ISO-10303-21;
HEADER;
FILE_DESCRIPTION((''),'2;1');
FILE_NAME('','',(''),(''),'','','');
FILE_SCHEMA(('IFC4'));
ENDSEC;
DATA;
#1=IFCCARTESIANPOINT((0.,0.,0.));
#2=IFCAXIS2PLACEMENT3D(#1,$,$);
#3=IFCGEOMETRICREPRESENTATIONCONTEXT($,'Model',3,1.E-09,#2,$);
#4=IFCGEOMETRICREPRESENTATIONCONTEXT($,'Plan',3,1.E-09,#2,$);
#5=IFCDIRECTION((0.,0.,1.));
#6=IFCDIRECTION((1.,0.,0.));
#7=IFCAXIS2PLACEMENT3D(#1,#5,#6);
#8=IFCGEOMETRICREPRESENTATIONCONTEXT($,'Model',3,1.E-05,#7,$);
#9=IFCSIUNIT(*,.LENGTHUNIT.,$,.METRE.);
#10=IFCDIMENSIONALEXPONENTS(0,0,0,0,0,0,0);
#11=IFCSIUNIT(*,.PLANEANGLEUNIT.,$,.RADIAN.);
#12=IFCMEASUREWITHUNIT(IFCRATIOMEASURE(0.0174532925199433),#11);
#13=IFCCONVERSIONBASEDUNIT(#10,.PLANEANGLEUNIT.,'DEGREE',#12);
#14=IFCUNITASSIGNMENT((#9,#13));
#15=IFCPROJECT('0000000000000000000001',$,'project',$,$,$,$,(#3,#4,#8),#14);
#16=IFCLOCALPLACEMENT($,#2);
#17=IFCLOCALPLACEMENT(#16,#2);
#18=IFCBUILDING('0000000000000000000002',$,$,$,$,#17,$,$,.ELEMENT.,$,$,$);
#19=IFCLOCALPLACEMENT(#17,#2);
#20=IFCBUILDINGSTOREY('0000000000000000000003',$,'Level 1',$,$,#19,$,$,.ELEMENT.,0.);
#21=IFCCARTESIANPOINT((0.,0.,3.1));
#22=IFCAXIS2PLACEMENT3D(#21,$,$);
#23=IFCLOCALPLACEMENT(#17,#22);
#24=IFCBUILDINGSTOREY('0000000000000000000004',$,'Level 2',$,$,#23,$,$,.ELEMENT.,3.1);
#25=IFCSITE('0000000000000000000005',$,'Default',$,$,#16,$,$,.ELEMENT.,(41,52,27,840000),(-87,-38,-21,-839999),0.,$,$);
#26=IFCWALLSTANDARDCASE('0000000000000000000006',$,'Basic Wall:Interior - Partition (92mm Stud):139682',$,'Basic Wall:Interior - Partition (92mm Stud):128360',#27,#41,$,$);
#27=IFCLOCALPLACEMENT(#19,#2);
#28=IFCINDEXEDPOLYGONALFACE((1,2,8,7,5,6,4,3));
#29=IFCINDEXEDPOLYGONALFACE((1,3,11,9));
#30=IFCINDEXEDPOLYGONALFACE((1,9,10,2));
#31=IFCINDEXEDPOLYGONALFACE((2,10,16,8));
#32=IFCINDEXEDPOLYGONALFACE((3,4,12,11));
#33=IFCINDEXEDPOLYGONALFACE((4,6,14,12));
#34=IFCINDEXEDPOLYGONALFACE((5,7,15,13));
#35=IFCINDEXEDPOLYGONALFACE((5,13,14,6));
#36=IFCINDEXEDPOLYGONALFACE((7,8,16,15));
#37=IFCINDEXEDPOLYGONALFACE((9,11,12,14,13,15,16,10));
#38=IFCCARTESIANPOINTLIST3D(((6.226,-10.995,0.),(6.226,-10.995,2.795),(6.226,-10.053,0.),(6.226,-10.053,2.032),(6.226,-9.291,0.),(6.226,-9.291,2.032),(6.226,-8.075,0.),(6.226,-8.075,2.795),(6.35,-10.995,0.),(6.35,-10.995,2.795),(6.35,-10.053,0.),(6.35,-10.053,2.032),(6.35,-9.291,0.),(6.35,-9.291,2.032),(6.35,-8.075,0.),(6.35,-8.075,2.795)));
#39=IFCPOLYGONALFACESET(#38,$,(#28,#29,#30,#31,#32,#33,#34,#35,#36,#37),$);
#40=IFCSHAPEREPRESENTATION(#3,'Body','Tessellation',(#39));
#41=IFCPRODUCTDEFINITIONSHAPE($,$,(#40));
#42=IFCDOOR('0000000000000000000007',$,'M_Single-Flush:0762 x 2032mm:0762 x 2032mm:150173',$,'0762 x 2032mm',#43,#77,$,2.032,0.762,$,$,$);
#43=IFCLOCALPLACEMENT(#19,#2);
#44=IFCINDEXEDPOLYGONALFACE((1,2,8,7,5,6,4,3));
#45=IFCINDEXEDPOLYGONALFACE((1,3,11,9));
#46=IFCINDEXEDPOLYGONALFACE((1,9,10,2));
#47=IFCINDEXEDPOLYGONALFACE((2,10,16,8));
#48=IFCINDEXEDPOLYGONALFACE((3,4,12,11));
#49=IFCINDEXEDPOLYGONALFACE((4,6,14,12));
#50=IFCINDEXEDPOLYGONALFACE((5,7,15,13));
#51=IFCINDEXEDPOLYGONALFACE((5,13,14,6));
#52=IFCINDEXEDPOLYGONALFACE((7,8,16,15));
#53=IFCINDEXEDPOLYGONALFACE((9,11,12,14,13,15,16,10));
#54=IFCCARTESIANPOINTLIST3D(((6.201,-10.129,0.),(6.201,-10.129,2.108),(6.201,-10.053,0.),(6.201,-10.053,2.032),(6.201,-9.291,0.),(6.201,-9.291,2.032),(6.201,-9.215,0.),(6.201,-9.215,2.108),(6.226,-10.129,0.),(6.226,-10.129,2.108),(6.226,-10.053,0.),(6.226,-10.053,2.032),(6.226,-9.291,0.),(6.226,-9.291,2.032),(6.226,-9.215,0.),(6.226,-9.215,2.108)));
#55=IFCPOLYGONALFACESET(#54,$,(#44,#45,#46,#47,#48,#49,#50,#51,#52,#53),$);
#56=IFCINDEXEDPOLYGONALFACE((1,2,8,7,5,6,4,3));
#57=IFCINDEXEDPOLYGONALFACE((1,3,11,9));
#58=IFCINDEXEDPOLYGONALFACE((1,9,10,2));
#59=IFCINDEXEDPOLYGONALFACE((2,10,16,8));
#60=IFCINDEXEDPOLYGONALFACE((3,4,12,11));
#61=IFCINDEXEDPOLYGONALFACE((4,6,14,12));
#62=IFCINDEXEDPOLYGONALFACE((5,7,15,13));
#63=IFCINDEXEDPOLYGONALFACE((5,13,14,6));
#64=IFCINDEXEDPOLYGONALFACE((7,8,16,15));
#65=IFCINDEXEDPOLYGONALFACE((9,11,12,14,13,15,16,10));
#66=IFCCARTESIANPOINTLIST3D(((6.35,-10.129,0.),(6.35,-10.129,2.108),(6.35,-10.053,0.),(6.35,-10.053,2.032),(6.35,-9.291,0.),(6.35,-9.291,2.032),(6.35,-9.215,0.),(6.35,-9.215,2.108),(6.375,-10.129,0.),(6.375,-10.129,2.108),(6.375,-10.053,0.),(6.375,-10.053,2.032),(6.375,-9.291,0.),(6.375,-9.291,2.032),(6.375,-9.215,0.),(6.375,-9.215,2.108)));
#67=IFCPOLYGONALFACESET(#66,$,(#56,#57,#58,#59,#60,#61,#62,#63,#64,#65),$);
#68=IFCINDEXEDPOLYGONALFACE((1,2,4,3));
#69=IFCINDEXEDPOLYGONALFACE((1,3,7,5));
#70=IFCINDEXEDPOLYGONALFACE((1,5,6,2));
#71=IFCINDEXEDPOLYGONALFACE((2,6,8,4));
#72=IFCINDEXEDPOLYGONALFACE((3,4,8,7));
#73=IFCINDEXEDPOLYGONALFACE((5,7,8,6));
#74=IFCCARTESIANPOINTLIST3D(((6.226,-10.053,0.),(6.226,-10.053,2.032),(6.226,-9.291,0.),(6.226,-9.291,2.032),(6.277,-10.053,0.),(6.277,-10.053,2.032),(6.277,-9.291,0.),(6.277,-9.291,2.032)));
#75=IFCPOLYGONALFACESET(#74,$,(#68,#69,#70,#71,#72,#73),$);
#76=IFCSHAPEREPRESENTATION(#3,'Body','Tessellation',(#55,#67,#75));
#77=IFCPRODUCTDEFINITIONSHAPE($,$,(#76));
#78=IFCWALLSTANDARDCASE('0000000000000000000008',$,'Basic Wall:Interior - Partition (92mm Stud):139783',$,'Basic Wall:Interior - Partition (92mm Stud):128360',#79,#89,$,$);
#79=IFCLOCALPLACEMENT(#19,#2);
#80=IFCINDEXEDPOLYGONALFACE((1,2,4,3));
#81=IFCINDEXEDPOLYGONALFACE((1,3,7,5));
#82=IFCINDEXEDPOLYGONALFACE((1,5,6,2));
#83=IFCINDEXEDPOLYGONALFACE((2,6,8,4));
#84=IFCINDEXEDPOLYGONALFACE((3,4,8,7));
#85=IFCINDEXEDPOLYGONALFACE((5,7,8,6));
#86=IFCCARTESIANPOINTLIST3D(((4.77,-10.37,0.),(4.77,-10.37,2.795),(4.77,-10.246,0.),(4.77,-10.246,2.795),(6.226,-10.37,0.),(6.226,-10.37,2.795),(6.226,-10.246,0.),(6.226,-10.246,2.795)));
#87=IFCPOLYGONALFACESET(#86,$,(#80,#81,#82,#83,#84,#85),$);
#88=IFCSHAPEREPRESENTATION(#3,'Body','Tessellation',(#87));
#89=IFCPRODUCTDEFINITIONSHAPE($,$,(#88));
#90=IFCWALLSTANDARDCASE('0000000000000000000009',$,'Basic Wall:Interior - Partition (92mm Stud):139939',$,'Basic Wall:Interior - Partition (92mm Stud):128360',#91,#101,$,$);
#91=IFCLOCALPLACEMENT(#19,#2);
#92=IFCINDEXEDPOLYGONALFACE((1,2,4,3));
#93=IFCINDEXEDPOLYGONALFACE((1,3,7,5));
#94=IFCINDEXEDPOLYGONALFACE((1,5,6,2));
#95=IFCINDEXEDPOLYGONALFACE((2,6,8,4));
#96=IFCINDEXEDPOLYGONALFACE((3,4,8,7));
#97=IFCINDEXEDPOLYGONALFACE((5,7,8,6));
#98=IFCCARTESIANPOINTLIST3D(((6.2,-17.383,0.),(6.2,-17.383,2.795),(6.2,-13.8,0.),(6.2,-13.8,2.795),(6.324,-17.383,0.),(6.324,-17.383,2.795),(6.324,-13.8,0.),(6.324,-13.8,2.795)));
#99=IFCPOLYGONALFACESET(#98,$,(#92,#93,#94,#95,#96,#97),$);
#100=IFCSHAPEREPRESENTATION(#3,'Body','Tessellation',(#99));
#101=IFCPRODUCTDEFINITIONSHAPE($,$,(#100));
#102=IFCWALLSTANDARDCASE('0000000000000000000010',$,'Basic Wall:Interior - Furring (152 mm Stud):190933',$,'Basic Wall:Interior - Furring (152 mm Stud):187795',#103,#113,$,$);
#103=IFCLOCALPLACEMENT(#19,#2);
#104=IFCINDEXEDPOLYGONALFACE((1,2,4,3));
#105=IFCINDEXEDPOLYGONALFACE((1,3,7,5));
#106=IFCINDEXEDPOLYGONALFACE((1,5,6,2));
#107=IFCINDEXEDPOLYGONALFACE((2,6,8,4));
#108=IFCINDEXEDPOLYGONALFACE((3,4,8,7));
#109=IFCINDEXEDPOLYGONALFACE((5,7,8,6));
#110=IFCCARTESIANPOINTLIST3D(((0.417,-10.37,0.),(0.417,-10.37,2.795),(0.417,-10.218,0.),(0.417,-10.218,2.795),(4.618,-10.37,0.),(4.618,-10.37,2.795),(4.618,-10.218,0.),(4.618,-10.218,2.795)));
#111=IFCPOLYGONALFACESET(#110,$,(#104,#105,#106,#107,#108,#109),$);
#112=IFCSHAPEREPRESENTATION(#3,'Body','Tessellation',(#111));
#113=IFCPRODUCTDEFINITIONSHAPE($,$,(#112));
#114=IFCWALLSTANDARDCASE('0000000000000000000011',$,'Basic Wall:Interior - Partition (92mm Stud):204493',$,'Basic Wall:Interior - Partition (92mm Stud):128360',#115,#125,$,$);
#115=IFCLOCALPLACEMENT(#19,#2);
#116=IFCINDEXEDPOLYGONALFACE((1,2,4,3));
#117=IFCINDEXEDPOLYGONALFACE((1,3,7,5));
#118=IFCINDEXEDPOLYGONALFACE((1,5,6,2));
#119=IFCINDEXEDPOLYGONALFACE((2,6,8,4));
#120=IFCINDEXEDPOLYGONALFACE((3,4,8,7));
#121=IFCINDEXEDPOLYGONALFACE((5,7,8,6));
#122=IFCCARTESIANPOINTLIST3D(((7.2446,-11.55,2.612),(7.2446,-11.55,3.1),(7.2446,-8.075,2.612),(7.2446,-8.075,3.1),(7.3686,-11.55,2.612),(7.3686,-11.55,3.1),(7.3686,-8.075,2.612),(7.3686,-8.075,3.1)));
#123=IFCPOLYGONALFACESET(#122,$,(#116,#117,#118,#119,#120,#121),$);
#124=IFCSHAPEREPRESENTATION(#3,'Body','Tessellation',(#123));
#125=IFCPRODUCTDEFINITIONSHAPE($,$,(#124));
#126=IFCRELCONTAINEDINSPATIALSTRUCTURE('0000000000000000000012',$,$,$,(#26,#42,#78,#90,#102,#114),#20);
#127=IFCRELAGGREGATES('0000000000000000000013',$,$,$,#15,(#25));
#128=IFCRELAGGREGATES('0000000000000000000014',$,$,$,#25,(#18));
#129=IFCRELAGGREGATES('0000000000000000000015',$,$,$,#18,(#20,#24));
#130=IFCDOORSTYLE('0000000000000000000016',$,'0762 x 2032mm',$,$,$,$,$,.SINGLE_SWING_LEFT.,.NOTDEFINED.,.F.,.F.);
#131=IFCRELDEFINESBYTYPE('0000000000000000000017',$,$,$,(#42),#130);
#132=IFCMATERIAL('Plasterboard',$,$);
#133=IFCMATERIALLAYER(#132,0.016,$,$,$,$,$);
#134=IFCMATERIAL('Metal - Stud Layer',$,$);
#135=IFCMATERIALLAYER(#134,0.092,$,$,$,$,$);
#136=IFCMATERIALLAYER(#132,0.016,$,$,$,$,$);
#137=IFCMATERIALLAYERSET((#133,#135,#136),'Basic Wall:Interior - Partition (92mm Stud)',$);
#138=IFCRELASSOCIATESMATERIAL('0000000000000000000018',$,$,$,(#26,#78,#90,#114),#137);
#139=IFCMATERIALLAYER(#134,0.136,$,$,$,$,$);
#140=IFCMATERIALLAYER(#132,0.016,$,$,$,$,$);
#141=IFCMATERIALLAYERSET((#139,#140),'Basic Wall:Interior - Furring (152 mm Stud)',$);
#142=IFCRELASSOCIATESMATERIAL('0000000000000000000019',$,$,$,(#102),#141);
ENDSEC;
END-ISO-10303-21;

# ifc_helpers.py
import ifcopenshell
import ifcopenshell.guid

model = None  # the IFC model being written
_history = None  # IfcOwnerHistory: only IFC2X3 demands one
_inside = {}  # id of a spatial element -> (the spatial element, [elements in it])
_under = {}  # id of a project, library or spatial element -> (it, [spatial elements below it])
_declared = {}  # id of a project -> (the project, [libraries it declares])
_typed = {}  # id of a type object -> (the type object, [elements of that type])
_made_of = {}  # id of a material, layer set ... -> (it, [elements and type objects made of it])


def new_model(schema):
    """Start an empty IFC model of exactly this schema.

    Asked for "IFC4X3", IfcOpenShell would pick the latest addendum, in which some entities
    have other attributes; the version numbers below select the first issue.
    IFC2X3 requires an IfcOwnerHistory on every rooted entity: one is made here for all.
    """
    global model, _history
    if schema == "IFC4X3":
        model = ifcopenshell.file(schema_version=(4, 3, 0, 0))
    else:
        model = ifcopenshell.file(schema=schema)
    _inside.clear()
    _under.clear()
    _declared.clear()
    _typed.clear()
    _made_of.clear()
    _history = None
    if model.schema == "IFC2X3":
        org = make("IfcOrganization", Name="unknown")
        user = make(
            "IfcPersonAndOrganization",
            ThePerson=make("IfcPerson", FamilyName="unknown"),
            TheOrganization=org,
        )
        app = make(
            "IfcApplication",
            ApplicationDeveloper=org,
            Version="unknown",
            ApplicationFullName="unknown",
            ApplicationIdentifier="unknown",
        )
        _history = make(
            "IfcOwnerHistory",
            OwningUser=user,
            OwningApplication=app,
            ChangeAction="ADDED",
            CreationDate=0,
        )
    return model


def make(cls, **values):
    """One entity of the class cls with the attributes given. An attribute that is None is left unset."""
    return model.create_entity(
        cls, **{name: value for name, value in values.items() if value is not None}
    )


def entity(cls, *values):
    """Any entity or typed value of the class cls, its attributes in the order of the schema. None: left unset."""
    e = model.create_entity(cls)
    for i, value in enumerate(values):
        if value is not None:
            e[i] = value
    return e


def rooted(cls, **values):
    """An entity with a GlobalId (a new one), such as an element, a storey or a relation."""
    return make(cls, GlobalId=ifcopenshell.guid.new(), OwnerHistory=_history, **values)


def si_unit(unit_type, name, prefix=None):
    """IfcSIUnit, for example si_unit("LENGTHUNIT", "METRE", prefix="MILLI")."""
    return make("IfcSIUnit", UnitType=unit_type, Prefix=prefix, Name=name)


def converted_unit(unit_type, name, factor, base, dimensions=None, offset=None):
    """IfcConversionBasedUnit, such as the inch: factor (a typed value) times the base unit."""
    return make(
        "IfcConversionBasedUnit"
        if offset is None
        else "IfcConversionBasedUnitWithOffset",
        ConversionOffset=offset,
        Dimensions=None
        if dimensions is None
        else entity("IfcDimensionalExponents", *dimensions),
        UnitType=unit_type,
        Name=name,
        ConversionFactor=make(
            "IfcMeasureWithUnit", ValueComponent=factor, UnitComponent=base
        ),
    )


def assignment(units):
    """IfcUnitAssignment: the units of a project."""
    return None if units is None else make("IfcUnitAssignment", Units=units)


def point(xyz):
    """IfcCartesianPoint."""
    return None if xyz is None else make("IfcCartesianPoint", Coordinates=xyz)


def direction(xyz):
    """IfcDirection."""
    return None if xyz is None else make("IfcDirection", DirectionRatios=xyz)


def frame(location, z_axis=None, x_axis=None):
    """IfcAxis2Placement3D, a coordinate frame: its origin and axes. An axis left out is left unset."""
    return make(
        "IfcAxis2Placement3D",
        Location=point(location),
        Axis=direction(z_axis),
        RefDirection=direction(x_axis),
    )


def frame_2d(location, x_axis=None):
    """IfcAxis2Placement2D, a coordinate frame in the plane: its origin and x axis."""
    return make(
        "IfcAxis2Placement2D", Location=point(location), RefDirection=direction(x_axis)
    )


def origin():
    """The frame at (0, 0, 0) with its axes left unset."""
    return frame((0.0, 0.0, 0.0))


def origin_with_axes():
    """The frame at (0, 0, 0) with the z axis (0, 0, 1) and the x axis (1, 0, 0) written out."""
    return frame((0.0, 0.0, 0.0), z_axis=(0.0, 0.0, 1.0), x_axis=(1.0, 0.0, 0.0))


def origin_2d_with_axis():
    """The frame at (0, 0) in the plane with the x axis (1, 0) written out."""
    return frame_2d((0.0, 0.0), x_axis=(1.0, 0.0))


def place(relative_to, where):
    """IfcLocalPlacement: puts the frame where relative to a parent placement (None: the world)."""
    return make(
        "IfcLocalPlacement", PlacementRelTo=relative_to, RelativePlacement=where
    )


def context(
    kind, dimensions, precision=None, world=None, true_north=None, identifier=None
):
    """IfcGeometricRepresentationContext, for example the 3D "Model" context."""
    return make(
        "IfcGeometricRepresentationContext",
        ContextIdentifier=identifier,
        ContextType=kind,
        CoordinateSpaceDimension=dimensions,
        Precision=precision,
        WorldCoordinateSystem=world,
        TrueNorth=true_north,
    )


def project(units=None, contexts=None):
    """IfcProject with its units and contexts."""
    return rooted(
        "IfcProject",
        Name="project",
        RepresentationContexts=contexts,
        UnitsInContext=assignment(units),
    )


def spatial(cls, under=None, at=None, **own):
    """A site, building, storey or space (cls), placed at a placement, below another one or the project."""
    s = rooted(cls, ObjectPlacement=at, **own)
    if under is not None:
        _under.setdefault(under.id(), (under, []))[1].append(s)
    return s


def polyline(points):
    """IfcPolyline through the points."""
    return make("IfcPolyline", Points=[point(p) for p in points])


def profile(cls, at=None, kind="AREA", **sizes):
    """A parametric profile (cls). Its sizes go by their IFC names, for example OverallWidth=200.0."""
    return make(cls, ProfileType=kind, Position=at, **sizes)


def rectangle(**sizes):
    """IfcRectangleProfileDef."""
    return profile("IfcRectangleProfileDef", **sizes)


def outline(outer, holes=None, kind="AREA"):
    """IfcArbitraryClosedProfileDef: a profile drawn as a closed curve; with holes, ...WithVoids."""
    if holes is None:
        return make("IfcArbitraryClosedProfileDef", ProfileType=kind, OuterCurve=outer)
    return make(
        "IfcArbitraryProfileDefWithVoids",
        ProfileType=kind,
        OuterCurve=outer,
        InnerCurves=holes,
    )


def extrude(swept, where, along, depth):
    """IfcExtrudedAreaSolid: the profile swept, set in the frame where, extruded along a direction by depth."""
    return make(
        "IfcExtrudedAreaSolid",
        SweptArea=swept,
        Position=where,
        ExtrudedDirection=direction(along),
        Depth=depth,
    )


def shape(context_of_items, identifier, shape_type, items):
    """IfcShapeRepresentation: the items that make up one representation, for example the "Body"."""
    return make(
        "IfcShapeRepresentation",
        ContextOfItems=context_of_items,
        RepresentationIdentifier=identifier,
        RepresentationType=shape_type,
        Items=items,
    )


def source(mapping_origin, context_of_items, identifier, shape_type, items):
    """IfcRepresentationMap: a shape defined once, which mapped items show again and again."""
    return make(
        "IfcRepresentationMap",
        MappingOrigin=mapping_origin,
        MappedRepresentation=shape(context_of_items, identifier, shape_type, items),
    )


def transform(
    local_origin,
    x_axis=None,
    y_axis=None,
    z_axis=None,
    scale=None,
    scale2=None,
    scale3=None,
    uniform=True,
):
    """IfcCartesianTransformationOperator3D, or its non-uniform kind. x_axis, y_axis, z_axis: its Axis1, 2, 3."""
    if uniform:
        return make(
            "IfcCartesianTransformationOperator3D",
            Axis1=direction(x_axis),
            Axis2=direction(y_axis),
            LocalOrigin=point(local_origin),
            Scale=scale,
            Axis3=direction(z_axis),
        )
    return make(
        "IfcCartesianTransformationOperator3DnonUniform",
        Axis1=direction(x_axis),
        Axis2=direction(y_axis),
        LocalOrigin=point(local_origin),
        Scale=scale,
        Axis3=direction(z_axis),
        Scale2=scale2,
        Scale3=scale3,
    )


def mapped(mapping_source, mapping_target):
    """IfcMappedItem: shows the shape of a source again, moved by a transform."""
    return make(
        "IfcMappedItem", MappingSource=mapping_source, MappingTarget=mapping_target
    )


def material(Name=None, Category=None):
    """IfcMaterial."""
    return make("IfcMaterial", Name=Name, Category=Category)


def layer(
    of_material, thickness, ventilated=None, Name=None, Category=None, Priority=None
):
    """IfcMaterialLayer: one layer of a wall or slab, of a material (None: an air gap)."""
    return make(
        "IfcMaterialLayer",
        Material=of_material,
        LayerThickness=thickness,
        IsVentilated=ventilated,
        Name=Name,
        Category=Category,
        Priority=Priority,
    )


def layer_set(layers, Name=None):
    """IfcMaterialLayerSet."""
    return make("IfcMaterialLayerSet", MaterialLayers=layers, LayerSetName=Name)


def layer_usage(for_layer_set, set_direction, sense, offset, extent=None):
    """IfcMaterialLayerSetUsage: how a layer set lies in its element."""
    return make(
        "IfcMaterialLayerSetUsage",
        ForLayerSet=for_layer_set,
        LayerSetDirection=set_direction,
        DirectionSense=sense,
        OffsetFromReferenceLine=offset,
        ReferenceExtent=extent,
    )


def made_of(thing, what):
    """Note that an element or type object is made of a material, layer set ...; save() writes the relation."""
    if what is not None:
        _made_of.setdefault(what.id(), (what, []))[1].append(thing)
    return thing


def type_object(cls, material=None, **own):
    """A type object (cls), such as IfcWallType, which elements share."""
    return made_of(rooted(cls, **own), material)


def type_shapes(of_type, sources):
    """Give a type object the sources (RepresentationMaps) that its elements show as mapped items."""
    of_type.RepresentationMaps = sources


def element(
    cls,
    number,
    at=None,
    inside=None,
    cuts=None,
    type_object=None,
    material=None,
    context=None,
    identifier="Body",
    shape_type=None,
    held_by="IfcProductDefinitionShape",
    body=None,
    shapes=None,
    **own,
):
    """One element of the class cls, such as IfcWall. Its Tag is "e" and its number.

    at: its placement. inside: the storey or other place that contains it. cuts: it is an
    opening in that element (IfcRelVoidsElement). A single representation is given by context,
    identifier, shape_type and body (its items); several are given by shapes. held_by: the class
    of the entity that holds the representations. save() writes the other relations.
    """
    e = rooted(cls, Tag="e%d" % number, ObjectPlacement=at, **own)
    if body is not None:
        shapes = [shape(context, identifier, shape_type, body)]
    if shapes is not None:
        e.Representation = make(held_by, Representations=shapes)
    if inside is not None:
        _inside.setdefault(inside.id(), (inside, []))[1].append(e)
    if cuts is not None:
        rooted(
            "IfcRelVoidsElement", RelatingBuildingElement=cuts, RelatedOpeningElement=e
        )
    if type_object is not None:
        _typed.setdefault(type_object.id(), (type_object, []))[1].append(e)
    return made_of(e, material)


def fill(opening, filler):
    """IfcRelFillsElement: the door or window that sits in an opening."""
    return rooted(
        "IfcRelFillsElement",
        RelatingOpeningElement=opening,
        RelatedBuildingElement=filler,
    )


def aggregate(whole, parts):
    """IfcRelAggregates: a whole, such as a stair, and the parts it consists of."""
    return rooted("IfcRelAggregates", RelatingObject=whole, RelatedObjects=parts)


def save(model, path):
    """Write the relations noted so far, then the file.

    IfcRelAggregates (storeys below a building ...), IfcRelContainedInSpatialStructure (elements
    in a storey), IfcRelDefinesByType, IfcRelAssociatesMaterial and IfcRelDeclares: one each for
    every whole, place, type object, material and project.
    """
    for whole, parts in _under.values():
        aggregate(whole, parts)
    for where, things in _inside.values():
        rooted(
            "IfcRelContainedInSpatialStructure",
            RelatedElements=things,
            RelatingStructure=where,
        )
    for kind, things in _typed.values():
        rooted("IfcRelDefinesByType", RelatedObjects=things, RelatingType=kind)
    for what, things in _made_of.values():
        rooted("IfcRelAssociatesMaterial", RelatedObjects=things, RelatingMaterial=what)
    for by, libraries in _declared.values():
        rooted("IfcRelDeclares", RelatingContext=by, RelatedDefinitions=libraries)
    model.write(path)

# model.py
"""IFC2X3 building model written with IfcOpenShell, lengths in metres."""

from ifc_helpers import new_model, entity, si_unit, converted_unit, frame, frame_2d, origin, origin_with_axes, origin_2d_with_axis, place, context, project, spatial, polyline, rectangle, outline, extrude, source, transform, mapped, material, layer, layer_set, layer_usage, type_object, type_shapes, element, fill, save


model = new_model("IFC2X3")

# Units and contexts
model_context_1 = context("Model", 3, precision=1e-09, world=origin())
plan_context = context("Plan", 3, precision=1e-09, world=origin())
model_context_2 = context("Model", 3, precision=1e-05, world=origin_with_axes())
ifc_project = project(units=[si_unit("LENGTHUNIT", "METRE"), converted_unit("PLANEANGLEUNIT", "DEGREE", entity("IfcRatioMeasure", 0.0174532925199433), si_unit("PLANEANGLEUNIT", "RADIAN"), dimensions=[0, 0, 0, 0, 0, 0, 0])], contexts=[model_context_1, plan_context, model_context_2])

# Site, building, storey
site_placement = place(None, origin())
site = spatial("IfcSite", under=ifc_project, at=site_placement, Name="Default", CompositionType="ELEMENT", RefLatitude=(41, 52, 27, 840000), RefLongitude=(-87, -38, -21, -839999), RefElevation=0.0)
building_placement = place(site_placement, origin())
building = spatial("IfcBuilding", under=site, at=building_placement, CompositionType="ELEMENT")
storey_1_placement = place(building_placement, origin())
storey_1 = spatial("IfcBuildingStorey", under=building, at=storey_1_placement, Name="Level 1", CompositionType="ELEMENT", Elevation=0.0)

# Shared definitions
ifc_material_1 = material(Name="Metal - Stud Layer")
ifc_material_2 = material(Name="Plasterboard")

# Wall, opening, door
ifc_layer_1 = layer(ifc_material_2, 0.016)
ifc_layer_2 = layer(ifc_material_1, 0.092)
ifc_layer_3 = layer(ifc_material_2, 0.016)
ifc_layer_set_1 = layer_set([ifc_layer_1, ifc_layer_2, ifc_layer_3], Name="Basic Wall:Interior - Partition (92mm Stud)")
ifc_layer_usage_1 = layer_usage(ifc_layer_set_1, "AXIS2", "NEGATIVE", 0.062)
wall_1_placement = place(storey_1_placement, frame((6.288, -10.995, 0.0), z_axis=(0.0, 0.0, 1.0), x_axis=(0.0, 1.0, 0.0)))
wall_1 = element("IfcWallStandardCase", 1, at=wall_1_placement, inside=storey_1, material=ifc_layer_usage_1, Name="Basic Wall:Interior - Partition (92mm Stud):139682", ObjectType="Basic Wall:Interior - Partition (92mm Stud):128360", context=model_context_1, shape_type="SweptSolid", body=[
    extrude(rectangle(XDim=2.92, YDim=0.124, at=frame_2d((1.46, 0.0), x_axis=(-1.0, 0.0))), origin(), (0.0, 0.0, 1.0), 2.795),
])
opening_1_placement = place(wall_1_placement, frame((0.942, -0.062, 0.0)))
opening_1 = element("IfcOpeningElement", 2, at=opening_1_placement, cuts=wall_1, ObjectType="Opening", context=model_context_1, shape_type="SweptSolid", body=[
    extrude(rectangle(XDim=0.762, YDim=2.032, at=frame_2d((1.016, 0.381), x_axis=(0.0, -1.0))), frame((0.0, 0.0, 0.0), z_axis=(0.0, 1.0, 0.0), x_axis=(0.0, 0.0, 1.0)), (0.0, 0.0, 1.0), 0.124),
])
door_style_1 = type_object("IfcDoorStyle", Name="0762 x 2032mm", ConstructionType="NOTDEFINED", OperationType="SINGLE_SWING_LEFT", ParameterTakesPrecedence=False, Sizeable=False)
shared_shape_1 = source(origin(), model_context_1, "Body", "SweptSolid", [
    extrude(outline(polyline([(-0.457, -1.073), (0.457, -1.073), (0.457, 1.035), (0.381, 1.035), (0.381, -0.997), (-0.381, -0.997), (-0.381, 1.035), (-0.457, 1.035), (-0.457, -1.073)])), frame((0.381, 0.149, 1.035), z_axis=(0.0, -1.0, 0.0), x_axis=(-1.0, 0.0, 0.0)), (0.0, 0.0, 1.0), 0.025),
    extrude(outline(polyline([(-1.073, -0.457), (1.035, -0.457), (1.035, -0.381), (-0.997, -0.381), (-0.997, 0.381), (1.035, 0.381), (1.035, 0.457), (-1.073, 0.457), (-1.073, -0.457)])), frame((0.381, 0.0, 1.035), z_axis=(0.0, -1.0, 0.0), x_axis=(0.0, 0.0, -1.0)), (0.0, 0.0, 1.0), 0.025),
    extrude(rectangle(XDim=0.762, YDim=0.051, at=origin_2d_with_axis()), frame((0.381, 0.0985, 0.0)), (0.0, 0.0, 1.0), 2.032),
])
type_shapes(door_style_1, [shared_shape_1])
door_1_placement = place(opening_1_placement, origin())
door_1 = element("IfcDoor", 3, at=door_1_placement, inside=storey_1, type_object=door_style_1, Name="M_Single-Flush:0762 x 2032mm:0762 x 2032mm:150173", ObjectType="0762 x 2032mm", OverallHeight=2.032, OverallWidth=0.762, context=model_context_1, shape_type="MappedRepresentation", body=[
    mapped(shared_shape_1, transform((0.0, 0.0, 0.0), scale=1.0)),
])
fill(opening_1, door_1)

# Walls
ifc_layer_usage_2 = layer_usage(ifc_layer_set_1, "AXIS2", "NEGATIVE", 0.062)
wall_2_placement = place(storey_1_placement, frame((4.77, -10.308, 0.0)))
element("IfcWallStandardCase", 4, at=wall_2_placement, inside=storey_1, material=ifc_layer_usage_2, Name="Basic Wall:Interior - Partition (92mm Stud):139783", ObjectType="Basic Wall:Interior - Partition (92mm Stud):128360", context=model_context_1, shape_type="SweptSolid", body=[
    extrude(rectangle(XDim=1.456, YDim=0.124, at=frame_2d((0.728, 0.0), x_axis=(-1.0, 0.0))), origin(), (0.0, 0.0, 1.0), 2.795),
])
ifc_layer_usage_3 = layer_usage(ifc_layer_set_1, "AXIS2", "NEGATIVE", 0.062)
wall_3_placement = place(storey_1_placement, frame((6.262, -13.8, 0.0), z_axis=(0.0, 0.0, 1.0), x_axis=(0.0, -1.0, 0.0)))
element("IfcWallStandardCase", 5, at=wall_3_placement, inside=storey_1, material=ifc_layer_usage_3, Name="Basic Wall:Interior - Partition (92mm Stud):139939", ObjectType="Basic Wall:Interior - Partition (92mm Stud):128360", context=model_context_1, shape_type="SweptSolid", body=[
    extrude(rectangle(XDim=3.583, YDim=0.124, at=frame_2d((1.7915, 0.0), x_axis=(-1.0, 0.0))), origin(), (0.0, 0.0, 1.0), 2.795),
])

# Shared definitions
storey_2_placement = place(building_placement, frame((0.0, 0.0, 3.1)))
storey_2 = spatial("IfcBuildingStorey", under=building, at=storey_2_placement, Name="Level 2", CompositionType="ELEMENT", Elevation=3.1)

# Walls
ifc_layer_4 = layer(ifc_material_1, 0.136)
ifc_layer_5 = layer(ifc_material_2, 0.016)
ifc_layer_set_2 = layer_set([ifc_layer_4, ifc_layer_5], Name="Basic Wall:Interior - Furring (152 mm Stud)")
ifc_layer_usage_4 = layer_usage(ifc_layer_set_2, "AXIS2", "NEGATIVE", 0.076)
wall_4_placement = place(storey_1_placement, frame((0.417, -10.294, 0.0)))
element("IfcWallStandardCase", 6, at=wall_4_placement, inside=storey_1, material=ifc_layer_usage_4, Name="Basic Wall:Interior - Furring (152 mm Stud):190933", ObjectType="Basic Wall:Interior - Furring (152 mm Stud):187795", context=model_context_1, shape_type="SweptSolid", body=[
    extrude(rectangle(XDim=4.201, YDim=0.152, at=frame_2d((2.1005, 0.0), x_axis=(-1.0, 0.0))), origin(), (0.0, 0.0, 1.0), 2.795),
])
ifc_layer_usage_5 = layer_usage(ifc_layer_set_1, "AXIS2", "NEGATIVE", 0.062)
wall_5_placement = place(storey_1_placement, frame((7.3066, -11.55, 2.612), z_axis=(0.0, 0.0, 1.0), x_axis=(0.0, 1.0, 0.0)))
element("IfcWallStandardCase", 7, at=wall_5_placement, inside=storey_1, material=ifc_layer_usage_5, Name="Basic Wall:Interior - Partition (92mm Stud):204493", ObjectType="Basic Wall:Interior - Partition (92mm Stud):128360", context=model_context_1, shape_type="SweptSolid", body=[
    extrude(rectangle(XDim=3.475, YDim=0.124, at=frame_2d((1.7375, 0.0), x_axis=(-1.0, 0.0))), origin(), (0.0, 0.0, 1.0), 0.488),
])

save(model, "model.ifc")
